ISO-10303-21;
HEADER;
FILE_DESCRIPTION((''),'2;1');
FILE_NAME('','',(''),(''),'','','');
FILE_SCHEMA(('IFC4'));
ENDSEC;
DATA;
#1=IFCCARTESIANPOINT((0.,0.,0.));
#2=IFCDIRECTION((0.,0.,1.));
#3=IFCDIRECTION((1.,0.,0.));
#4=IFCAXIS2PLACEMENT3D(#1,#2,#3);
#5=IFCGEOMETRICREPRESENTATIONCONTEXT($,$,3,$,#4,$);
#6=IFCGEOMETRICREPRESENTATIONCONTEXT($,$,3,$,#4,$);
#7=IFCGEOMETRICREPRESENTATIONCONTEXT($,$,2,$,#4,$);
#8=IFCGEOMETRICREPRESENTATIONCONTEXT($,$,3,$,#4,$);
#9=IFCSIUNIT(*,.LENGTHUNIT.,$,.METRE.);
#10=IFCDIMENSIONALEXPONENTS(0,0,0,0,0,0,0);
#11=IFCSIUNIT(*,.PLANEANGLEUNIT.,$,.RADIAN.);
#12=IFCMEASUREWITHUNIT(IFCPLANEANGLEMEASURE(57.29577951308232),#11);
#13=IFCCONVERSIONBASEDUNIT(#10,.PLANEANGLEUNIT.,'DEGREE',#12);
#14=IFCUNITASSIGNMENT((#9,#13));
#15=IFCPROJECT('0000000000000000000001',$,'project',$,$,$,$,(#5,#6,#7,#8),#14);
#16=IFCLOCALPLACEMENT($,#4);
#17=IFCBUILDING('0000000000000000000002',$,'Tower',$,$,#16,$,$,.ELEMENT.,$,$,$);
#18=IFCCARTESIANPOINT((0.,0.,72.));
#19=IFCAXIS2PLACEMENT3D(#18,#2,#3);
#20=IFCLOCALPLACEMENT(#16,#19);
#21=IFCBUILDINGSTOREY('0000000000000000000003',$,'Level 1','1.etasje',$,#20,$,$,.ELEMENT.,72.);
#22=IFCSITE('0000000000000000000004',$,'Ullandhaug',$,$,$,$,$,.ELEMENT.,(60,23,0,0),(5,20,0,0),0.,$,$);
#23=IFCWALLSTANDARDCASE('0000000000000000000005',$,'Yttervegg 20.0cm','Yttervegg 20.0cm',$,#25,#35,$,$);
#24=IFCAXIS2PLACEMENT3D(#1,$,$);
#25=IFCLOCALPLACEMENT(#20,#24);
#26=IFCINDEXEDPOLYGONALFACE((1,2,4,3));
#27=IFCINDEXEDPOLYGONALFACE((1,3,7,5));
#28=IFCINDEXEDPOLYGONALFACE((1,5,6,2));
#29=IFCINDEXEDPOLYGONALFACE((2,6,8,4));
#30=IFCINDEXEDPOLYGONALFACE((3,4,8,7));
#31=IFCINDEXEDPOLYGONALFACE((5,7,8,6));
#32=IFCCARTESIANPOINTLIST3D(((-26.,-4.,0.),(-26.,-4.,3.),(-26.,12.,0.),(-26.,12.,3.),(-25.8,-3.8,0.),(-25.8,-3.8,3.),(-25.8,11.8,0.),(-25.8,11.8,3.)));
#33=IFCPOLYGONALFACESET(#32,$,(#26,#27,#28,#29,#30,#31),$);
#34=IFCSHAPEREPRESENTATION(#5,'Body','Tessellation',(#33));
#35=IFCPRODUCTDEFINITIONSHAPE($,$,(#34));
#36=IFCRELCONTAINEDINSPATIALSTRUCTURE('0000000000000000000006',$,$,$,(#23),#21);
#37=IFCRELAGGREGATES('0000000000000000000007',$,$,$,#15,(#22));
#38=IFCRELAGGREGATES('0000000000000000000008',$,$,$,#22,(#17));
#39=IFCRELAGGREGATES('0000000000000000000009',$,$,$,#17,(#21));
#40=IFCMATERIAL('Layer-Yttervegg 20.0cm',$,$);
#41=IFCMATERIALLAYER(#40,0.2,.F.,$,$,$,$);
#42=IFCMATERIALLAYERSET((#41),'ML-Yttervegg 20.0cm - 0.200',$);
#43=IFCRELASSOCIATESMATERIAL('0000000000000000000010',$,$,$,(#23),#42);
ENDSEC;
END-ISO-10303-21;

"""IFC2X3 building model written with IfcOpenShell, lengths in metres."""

from ifc_helpers import new_model, entity, si_unit, converted_unit, frame, origin_with_axes, place, context, project, spatial, polyline, outline, extrude, material, layer, layer_set, layer_usage, element, save


model = new_model("IFC2X3")

# Units and contexts
context_of_model_1 = context(None, 3, world=origin_with_axes())
context_of_model_2 = context(None, 3, world=origin_with_axes())
context_of_model_3 = context(None, 2, world=origin_with_axes())
context_of_model_4 = context(None, 3, world=origin_with_axes())
ifc_project = project(units=[si_unit("LENGTHUNIT", "METRE"), converted_unit("PLANEANGLEUNIT", "DEGREE", entity("IfcPlaneAngleMeasure", 57.29577951308232), si_unit("PLANEANGLEUNIT", "RADIAN"), dimensions=[0, 0, 0, 0, 0, 0, 0])], contexts=[context_of_model_1, context_of_model_2, context_of_model_3, context_of_model_4])

# Site, building, storey
site = spatial("IfcSite", under=ifc_project, Name="Ullandhaug", CompositionType="ELEMENT", RefLatitude=(60, 23, 0, 0), RefLongitude=(5, 20, 0, 0), RefElevation=0.0)
building_placement = place(None, origin_with_axes())
building = spatial("IfcBuilding", under=site, at=building_placement, Name="Tower", CompositionType="ELEMENT")
storey_placement = place(building_placement, frame((0.0, 0.0, 72.0), z_axis=(0.0, 0.0, 1.0), x_axis=(1.0, 0.0, 0.0)))
storey = spatial("IfcBuildingStorey", under=building, at=storey_placement, Name="Level 1", Description="1.etasje", CompositionType="ELEMENT", Elevation=72.0)

# Shared definitions
ifc_material_1 = material(Name="Layer-Yttervegg 20.0cm")
ifc_layer_1 = layer(ifc_material_1, 0.2, ventilated=False)
ifc_layer_set_1 = layer_set([ifc_layer_1], Name="ML-Yttervegg 20.0cm - 0.200")
ifc_layer_usage_1 = layer_usage(ifc_layer_set_1, "AXIS2", "POSITIVE", 0.0)

# Wall
wall_1_placement = place(storey_placement, frame((-26.0, 12.0, 0.0), z_axis=(0.0, 0.0, 1.0), x_axis=(0.0, -1.0, 0.0)))
element("IfcWallStandardCase", 1, at=wall_1_placement, inside=storey, material=ifc_layer_usage_1, Name="Yttervegg 20.0cm", Description="Yttervegg 20.0cm", context=context_of_model_1, shape_type="SweptSolid", body=[
    extrude(outline(polyline([(0.0, 0.0), (16.0, 0.0), (15.8, 0.2), (0.2, 0.2), (0.0, 0.0)])), frame((0.0, 0.0, 0.0), z_axis=(0.0, 0.0, 1.0), x_axis=(1.0, 0.0, 0.0)), (0.0, 0.0, 1.0), 3.0),
])

save(model, "model.ifc")
